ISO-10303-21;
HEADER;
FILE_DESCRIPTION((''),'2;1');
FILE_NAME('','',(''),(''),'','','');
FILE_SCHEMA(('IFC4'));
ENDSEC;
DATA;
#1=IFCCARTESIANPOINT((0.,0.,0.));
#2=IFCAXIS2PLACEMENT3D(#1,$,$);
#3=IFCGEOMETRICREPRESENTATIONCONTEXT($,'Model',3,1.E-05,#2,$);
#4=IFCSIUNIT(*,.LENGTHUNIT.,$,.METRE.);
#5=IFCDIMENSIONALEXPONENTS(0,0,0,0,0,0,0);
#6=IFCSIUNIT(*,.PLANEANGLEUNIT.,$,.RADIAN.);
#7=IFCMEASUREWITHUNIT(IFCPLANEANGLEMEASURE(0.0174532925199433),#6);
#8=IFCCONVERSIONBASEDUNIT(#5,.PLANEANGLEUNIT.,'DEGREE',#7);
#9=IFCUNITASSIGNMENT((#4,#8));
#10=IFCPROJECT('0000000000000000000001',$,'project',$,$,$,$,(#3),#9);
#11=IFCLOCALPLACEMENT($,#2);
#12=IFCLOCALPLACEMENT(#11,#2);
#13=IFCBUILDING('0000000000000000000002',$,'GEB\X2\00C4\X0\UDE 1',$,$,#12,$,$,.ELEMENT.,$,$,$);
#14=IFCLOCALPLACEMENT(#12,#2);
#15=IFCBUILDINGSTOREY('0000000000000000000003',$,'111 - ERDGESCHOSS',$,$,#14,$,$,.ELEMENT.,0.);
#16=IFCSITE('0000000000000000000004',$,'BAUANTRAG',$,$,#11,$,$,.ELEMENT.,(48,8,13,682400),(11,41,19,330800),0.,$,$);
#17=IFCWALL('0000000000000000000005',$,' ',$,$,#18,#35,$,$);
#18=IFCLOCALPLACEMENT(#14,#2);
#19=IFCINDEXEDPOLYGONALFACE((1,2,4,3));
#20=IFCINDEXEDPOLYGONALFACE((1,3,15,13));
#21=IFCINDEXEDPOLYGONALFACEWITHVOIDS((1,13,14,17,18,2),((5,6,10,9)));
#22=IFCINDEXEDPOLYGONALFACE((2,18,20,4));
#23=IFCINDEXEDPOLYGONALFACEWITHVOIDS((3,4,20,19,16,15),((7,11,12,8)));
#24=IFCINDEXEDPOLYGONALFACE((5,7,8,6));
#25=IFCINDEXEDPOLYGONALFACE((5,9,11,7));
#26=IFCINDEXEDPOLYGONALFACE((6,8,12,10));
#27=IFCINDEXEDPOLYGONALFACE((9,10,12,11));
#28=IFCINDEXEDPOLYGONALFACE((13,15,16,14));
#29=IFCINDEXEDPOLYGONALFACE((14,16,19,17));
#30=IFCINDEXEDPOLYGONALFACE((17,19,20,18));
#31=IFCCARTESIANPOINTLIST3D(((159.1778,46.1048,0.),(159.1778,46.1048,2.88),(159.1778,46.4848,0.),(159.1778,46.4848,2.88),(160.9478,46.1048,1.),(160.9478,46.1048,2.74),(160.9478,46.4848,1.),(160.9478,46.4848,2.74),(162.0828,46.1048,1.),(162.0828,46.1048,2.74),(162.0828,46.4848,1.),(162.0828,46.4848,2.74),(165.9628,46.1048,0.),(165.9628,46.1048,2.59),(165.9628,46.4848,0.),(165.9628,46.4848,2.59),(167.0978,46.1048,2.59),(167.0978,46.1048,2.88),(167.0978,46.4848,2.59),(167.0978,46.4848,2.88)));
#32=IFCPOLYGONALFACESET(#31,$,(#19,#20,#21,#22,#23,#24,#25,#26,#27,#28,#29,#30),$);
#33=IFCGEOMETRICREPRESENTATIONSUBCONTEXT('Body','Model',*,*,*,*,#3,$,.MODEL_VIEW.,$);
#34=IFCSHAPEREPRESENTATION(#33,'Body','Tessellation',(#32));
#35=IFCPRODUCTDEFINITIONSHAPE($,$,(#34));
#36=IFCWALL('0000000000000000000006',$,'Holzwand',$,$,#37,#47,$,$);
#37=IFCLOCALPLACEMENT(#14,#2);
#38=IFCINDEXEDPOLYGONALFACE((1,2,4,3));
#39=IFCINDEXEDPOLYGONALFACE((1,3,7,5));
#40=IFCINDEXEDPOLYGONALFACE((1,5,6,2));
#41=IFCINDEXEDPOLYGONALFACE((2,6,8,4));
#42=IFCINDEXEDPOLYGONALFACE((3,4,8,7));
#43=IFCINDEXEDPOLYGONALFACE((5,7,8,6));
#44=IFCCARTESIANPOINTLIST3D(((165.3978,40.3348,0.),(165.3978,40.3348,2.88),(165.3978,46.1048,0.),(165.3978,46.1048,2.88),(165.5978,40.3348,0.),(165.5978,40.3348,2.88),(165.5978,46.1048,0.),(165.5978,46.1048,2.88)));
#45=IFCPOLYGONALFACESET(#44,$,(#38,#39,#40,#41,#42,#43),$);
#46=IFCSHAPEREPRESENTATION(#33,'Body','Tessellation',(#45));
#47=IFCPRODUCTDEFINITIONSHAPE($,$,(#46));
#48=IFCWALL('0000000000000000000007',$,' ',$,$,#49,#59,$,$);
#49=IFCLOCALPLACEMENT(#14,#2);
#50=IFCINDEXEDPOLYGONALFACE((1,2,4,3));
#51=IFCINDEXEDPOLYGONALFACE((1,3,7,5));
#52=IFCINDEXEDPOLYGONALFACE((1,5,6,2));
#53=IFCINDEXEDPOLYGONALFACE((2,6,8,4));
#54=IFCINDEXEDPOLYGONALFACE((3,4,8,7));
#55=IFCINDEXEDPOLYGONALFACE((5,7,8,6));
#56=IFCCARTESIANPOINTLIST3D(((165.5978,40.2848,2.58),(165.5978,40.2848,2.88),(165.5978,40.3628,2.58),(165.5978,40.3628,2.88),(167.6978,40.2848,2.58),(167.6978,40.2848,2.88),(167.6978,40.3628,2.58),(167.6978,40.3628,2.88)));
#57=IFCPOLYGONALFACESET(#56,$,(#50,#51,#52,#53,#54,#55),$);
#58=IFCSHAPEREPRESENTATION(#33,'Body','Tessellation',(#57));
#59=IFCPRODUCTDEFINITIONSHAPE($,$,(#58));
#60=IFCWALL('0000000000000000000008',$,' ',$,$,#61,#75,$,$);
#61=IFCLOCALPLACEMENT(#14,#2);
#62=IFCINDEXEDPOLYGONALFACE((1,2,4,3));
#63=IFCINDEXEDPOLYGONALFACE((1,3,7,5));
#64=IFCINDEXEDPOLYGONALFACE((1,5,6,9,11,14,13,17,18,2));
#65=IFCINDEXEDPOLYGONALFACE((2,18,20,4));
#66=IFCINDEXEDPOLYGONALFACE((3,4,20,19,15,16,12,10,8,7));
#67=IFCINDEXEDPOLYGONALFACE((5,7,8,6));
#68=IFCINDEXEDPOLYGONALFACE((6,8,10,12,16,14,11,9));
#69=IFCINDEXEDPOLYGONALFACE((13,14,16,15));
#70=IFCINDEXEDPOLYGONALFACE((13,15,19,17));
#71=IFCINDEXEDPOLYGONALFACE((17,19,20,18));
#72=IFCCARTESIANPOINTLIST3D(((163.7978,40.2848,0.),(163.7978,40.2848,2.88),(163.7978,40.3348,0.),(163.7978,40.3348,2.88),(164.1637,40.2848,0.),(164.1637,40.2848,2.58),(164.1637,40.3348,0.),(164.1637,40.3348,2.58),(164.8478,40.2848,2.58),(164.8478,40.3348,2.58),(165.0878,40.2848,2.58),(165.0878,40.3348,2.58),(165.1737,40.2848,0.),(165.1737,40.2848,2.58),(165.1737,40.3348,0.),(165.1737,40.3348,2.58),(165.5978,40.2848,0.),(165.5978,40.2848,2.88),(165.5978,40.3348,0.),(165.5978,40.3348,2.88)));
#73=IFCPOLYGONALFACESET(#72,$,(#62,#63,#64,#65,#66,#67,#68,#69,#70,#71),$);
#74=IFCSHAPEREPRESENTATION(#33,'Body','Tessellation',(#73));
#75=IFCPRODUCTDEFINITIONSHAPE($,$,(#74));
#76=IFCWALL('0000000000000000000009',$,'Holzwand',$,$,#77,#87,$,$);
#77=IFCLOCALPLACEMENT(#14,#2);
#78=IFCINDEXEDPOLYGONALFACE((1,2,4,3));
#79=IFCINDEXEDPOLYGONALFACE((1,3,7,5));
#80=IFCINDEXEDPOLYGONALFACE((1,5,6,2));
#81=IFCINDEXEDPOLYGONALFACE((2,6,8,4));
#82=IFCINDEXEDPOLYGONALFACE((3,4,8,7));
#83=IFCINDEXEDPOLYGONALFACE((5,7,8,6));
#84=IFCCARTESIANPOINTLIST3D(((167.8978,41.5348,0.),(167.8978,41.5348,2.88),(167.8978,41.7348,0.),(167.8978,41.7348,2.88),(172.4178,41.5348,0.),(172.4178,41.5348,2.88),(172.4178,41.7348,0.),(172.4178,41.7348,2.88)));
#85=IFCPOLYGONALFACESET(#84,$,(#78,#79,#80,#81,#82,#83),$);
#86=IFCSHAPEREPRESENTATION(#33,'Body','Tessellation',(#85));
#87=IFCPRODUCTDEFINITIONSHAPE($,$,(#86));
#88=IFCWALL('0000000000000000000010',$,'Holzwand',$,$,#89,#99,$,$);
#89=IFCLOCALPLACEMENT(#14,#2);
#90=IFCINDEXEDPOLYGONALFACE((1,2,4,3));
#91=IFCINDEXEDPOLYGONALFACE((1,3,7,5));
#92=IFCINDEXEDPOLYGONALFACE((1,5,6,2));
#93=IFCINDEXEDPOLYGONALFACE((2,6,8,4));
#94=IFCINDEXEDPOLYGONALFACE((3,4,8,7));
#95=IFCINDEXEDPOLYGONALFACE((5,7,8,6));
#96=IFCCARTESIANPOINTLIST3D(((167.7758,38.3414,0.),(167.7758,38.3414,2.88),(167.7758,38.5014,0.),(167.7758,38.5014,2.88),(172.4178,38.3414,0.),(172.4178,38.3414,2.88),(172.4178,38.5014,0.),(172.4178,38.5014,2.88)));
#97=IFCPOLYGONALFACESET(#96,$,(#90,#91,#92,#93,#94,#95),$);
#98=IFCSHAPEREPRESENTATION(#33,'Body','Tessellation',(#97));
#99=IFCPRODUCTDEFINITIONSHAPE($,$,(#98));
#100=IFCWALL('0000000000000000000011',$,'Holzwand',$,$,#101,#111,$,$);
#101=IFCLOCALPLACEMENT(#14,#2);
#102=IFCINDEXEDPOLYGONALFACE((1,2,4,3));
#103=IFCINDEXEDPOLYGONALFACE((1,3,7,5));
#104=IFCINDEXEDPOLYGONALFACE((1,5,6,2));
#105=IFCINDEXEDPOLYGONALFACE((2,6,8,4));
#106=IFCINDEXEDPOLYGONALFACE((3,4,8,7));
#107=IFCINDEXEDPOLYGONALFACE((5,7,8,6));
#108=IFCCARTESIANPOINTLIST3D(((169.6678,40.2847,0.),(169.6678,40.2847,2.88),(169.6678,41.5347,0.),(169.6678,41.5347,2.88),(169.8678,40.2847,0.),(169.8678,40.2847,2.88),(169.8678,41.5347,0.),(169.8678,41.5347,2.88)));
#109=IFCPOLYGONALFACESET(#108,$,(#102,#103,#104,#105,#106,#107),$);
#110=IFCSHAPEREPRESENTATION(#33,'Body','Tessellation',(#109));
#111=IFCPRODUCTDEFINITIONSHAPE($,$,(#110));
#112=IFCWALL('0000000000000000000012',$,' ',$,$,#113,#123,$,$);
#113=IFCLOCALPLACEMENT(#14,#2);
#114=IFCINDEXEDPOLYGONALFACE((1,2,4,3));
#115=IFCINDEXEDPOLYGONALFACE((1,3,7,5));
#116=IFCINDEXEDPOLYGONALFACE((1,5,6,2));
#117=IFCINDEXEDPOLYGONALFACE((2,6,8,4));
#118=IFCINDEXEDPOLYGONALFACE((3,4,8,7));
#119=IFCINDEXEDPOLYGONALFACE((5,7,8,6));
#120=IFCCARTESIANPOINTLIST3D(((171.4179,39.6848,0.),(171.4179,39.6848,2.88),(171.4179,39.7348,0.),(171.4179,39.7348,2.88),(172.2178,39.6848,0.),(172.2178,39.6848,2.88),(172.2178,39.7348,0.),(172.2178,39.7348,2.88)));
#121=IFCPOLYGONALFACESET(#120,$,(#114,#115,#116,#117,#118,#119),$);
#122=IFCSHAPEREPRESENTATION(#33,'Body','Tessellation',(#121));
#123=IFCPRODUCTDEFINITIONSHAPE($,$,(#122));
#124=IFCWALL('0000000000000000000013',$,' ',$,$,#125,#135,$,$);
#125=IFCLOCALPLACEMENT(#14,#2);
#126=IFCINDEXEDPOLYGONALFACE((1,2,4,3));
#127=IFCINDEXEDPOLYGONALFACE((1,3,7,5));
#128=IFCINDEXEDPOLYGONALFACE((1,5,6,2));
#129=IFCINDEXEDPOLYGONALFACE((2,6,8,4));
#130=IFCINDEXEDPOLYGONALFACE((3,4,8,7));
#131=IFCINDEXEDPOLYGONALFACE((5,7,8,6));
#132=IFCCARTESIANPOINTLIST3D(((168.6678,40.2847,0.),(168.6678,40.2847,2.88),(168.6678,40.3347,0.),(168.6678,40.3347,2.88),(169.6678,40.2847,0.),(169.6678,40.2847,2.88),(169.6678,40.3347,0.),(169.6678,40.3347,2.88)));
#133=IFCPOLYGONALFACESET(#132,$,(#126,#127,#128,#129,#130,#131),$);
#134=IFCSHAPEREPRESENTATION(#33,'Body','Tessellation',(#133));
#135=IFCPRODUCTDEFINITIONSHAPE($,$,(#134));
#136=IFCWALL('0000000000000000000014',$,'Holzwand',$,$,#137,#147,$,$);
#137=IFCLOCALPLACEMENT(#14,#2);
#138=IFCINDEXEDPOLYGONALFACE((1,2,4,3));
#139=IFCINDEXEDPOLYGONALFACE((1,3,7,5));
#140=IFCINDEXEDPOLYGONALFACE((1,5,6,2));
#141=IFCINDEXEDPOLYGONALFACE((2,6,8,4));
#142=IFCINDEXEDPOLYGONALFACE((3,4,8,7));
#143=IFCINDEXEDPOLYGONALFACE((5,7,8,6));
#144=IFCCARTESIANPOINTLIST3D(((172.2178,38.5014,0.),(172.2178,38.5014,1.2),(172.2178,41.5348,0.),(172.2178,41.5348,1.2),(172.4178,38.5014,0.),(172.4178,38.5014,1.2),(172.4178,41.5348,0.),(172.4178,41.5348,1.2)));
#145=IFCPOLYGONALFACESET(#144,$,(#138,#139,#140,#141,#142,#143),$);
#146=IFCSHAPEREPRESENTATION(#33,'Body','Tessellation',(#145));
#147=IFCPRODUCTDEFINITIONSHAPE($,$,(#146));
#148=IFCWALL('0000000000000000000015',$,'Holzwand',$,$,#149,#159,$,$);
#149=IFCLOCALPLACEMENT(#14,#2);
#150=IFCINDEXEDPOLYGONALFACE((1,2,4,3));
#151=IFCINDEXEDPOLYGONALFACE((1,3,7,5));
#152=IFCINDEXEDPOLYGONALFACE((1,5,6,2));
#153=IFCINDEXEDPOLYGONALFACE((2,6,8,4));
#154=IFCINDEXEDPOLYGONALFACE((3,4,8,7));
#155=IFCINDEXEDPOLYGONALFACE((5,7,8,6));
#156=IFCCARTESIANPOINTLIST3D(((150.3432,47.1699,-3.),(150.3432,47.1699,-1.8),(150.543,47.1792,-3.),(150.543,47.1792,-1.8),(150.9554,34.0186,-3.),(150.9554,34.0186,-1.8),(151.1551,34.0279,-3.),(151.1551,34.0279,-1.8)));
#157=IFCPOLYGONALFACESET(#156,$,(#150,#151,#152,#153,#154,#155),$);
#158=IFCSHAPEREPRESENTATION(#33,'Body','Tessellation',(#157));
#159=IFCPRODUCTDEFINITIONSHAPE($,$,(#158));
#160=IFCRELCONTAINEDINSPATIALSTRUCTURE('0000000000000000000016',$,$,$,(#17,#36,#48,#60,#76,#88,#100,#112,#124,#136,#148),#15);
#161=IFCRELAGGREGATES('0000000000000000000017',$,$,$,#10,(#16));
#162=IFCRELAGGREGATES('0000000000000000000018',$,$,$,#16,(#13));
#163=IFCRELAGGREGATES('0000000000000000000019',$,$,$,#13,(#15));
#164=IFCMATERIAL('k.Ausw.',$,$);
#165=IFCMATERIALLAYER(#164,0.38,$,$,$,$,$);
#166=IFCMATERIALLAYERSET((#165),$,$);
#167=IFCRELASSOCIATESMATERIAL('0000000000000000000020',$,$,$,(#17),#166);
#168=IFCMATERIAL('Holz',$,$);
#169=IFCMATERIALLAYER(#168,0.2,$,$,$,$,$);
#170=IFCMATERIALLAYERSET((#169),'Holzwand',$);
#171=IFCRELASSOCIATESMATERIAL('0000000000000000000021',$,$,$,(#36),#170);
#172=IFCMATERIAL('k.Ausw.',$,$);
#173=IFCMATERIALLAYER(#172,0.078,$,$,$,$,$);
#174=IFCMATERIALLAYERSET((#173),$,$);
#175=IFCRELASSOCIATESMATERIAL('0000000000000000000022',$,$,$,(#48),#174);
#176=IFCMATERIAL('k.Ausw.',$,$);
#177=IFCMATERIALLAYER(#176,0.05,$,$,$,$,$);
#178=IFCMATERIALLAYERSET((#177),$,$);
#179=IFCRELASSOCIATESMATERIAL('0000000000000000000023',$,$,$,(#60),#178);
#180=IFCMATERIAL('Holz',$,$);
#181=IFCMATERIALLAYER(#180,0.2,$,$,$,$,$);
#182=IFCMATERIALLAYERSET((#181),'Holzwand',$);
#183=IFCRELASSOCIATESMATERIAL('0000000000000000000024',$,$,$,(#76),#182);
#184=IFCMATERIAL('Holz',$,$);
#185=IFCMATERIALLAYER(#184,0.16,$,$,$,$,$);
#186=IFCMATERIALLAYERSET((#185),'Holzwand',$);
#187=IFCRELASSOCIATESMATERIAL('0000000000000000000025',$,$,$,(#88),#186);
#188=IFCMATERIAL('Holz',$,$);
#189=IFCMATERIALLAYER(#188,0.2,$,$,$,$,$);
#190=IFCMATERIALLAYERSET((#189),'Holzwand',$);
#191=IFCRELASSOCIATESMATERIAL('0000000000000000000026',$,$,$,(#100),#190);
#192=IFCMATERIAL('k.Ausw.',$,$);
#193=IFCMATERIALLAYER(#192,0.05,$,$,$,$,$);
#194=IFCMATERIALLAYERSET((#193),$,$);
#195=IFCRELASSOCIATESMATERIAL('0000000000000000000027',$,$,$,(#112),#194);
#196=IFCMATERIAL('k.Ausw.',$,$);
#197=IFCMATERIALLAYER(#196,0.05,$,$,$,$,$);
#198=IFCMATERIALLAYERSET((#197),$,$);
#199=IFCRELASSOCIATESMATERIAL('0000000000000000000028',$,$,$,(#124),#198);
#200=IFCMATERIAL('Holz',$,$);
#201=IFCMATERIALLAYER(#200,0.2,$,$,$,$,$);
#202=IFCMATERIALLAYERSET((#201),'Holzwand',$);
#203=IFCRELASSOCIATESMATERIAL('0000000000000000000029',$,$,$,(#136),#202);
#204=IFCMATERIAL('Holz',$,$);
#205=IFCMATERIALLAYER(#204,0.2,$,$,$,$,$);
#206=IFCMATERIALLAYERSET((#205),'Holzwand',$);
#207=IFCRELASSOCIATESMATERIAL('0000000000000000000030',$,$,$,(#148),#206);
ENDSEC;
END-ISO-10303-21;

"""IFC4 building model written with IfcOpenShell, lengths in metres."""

from ifc_helpers import new_model, entity, si_unit, converted_unit, frame, frame_2d, origin, origin_with_axes, place, context, subcontext, project, spatial, polyline, rectangle, outline, extrude, material, layer, layer_set, layer_usage, element, save


model = new_model("IFC4")

# Units and contexts
model_context = context("Model", 3, precision=1e-05, world=origin())
body_context = subcontext(model_context, "Body", "Model", "MODEL_VIEW")
ifc_project = project(units=[si_unit("LENGTHUNIT", "METRE"), converted_unit("PLANEANGLEUNIT", "DEGREE", entity("IfcPlaneAngleMeasure", 0.0174532925199433), si_unit("PLANEANGLEUNIT", "RADIAN"), dimensions=[0, 0, 0, 0, 0, 0, 0])], contexts=[model_context])

# Site, building, storey
site_placement = place(None, origin())
site = spatial("IfcSite", under=ifc_project, at=site_placement, Name="BAUANTRAG", CompositionType="ELEMENT", RefLatitude=(48, 8, 13, 682400), RefLongitude=(11, 41, 19, 330800), RefElevation=0.0)
building_placement = place(site_placement, origin())
building = spatial("IfcBuilding", under=site, at=building_placement, Name="GEBÄUDE 1", CompositionType="ELEMENT")
storey_placement = place(building_placement, origin())
storey = spatial("IfcBuildingStorey", under=building, at=storey_placement, Name="111 - ERDGESCHOSS", CompositionType="ELEMENT", Elevation=0.0)

# Wall, openings
ifc_material_1 = material(Name="k.Ausw.")
ifc_layer_1 = layer(ifc_material_1, 0.38)
ifc_layer_set_1 = layer_set([ifc_layer_1])
ifc_layer_usage_1 = layer_usage(ifc_layer_set_1, "AXIS2", "POSITIVE", 0.0)
wall_1_placement = place(storey_placement, frame((167.0978, 46.4848, 0.0), z_axis=(0.0, 0.0, 1.0), x_axis=(-1.0, 0.0, 0.0)))
wall_1 = element("IfcWall", 1, at=wall_1_placement, inside=storey, material=ifc_layer_usage_1, Name=" ", context=body_context, shape_type="SweptSolid", body=[
    extrude(rectangle(XDim=7.92, YDim=0.38, at=frame_2d((3.96, 0.19), x_axis=(1.0, 0.0))), origin_with_axes(), (0.0, 0.0, 1.0), 2.88),
])
opening_1_placement = place(wall_1_placement, frame((6.15, 0.38, 1.0), z_axis=(0.0, -1.0, 0.0), x_axis=(0.0, 0.0, 1.0)))
element("IfcOpeningElement", 2, at=opening_1_placement, cuts=wall_1, ObjectType="Opening", context=body_context, shape_type="SweptSolid", body=[
    extrude(outline(polyline([(0.0, 1.135), (1.74, 1.135), (1.74, 0.0), (0.0, 0.0), (0.0, 1.135)])), origin_with_axes(), (0.0, 0.0, 1.0), 0.38),
])
opening_2_placement = place(wall_1_placement, frame((0.0, 0.0, -0.15), z_axis=(0.0, 1.0, 0.0), x_axis=(0.0, 0.0, 1.0)))
element("IfcOpeningElement", 3, at=opening_2_placement, cuts=wall_1, ObjectType="Opening", context=body_context, shape_type="SweptSolid", body=[
    extrude(outline(polyline([(0.0, 1.135), (2.74, 1.135), (2.74, 0.0), (0.0, 0.0), (0.0, 1.135)])), origin_with_axes(), (0.0, 0.0, 1.0), 0.38),
])

# Wall
ifc_material_2 = material(Name="Holz")
ifc_layer_2 = layer(ifc_material_2, 0.2)
ifc_layer_set_2 = layer_set([ifc_layer_2], Name="Holzwand")
ifc_layer_usage_2 = layer_usage(ifc_layer_set_2, "AXIS2", "POSITIVE", 0.0)
wall_2_placement = place(storey_placement, frame((165.3978, 46.1048, 0.0), z_axis=(0.0, 0.0, 1.0), x_axis=(0.0, -1.0, 0.0)))
element("IfcWall", 4, at=wall_2_placement, inside=storey, material=ifc_layer_usage_2, Name="Holzwand", context=body_context, shape_type="SweptSolid", body=[
    extrude(rectangle(XDim=5.77, YDim=0.2, at=frame_2d((2.885, 0.1), x_axis=(1.0, 0.0))), origin_with_axes(), (0.0, 0.0, 1.0), 2.88),
])

# Wall, opening
ifc_material_3 = material(Name="k.Ausw.")
ifc_layer_3 = layer(ifc_material_3, 0.078)
ifc_layer_set_3 = layer_set([ifc_layer_3])
ifc_layer_usage_3 = layer_usage(ifc_layer_set_3, "AXIS2", "POSITIVE", 0.0)
wall_3_placement = place(storey_placement, frame((165.5978, 40.2848, 0.0)))
wall_3 = element("IfcWall", 5, at=wall_3_placement, inside=storey, material=ifc_layer_usage_3, Name=" ", context=body_context, shape_type="SweptSolid", body=[
    extrude(rectangle(XDim=2.1, YDim=0.078, at=frame_2d((1.05, 0.039), x_axis=(1.0, 0.0))), origin_with_axes(), (0.0, 0.0, 1.0), 2.88),
])
opening_3_placement = place(wall_3_placement, frame((0.0, 0.0, -0.14), z_axis=(0.0, 1.0, 0.0), x_axis=(0.0, 0.0, 1.0)))
element("IfcOpeningElement", 6, at=opening_3_placement, cuts=wall_3, ObjectType="Opening", context=body_context, shape_type="SweptSolid", body=[
    extrude(outline(polyline([(0.0, 2.1), (2.72, 2.1), (2.72, 0.0), (0.0, 0.0), (0.0, 2.1)])), origin_with_axes(), (0.0, 0.0, 1.0), 0.078),
])

# Wall, openings
ifc_material_4 = material(Name="k.Ausw.")
ifc_layer_4 = layer(ifc_material_4, 0.05)
ifc_layer_set_4 = layer_set([ifc_layer_4])
ifc_layer_usage_4 = layer_usage(ifc_layer_set_4, "AXIS2", "POSITIVE", 0.0)
wall_4_placement = place(storey_placement, frame((165.5978, 40.3348, 0.0), z_axis=(0.0, 0.0, 1.0), x_axis=(-1.0, 0.0, 0.0)))
wall_4 = element("IfcWall", 7, at=wall_4_placement, inside=storey, material=ifc_layer_usage_4, Name=" ", context=body_context, shape_type="SweptSolid", body=[
    extrude(rectangle(XDim=1.8, YDim=0.05, at=frame_2d((0.9, 0.025), x_axis=(1.0, 0.0))), origin_with_axes(), (0.0, 0.0, 1.0), 2.88),
])
opening_4_placement = place(wall_4_placement, frame((1.4341, 0.05, -0.14), z_axis=(0.0, -1.0, 0.0), x_axis=(0.0, 0.0, 1.0)))
element("IfcOpeningElement", 8, at=opening_4_placement, cuts=wall_4, ObjectType="Opening", context=body_context, shape_type="SweptSolid", body=[
    extrude(outline(polyline([(0.0, 1.01), (2.72, 1.01), (2.72, 0.0), (0.0, 0.0), (0.0, 1.01)])), origin_with_axes(), (0.0, 0.0, 1.0), 0.05),
])
opening_5_placement = place(wall_4_placement, frame((0.51, 0.0, -0.14), z_axis=(0.0, 1.0, 0.0), x_axis=(0.0, 0.0, 1.0)))
element("IfcOpeningElement", 9, at=opening_5_placement, cuts=wall_4, ObjectType="Opening", context=body_context, shape_type="SweptSolid", body=[
    extrude(outline(polyline([(0.0, 0.24), (2.72, 0.24), (2.72, 0.0), (0.0, 0.0), (0.0, 0.24)])), origin_with_axes(), (0.0, 0.0, 1.0), 0.05),
])

# Walls
ifc_material_5 = material(Name="Holz")
ifc_layer_5 = layer(ifc_material_5, 0.2)
ifc_layer_set_5 = layer_set([ifc_layer_5], Name="Holzwand")
ifc_layer_usage_5 = layer_usage(ifc_layer_set_5, "AXIS2", "POSITIVE", 0.0)
wall_5_placement = place(storey_placement, frame((172.4178, 41.7348, 0.0), z_axis=(0.0, 0.0, 1.0), x_axis=(-1.0, 0.0, 0.0)))
element("IfcWall", 10, at=wall_5_placement, inside=storey, material=ifc_layer_usage_5, Name="Holzwand", context=body_context, shape_type="SweptSolid", body=[
    extrude(rectangle(XDim=4.52, YDim=0.2, at=frame_2d((2.26, 0.1), x_axis=(1.0, 0.0))), origin_with_axes(), (0.0, 0.0, 1.0), 2.88),
])
ifc_material_6 = material(Name="Holz")
ifc_layer_6 = layer(ifc_material_6, 0.16)
ifc_layer_set_6 = layer_set([ifc_layer_6], Name="Holzwand")
ifc_layer_usage_6 = layer_usage(ifc_layer_set_6, "AXIS2", "POSITIVE", 0.0)
wall_6_placement = place(storey_placement, frame((172.4178, 38.5014, 0.0), z_axis=(0.0, 0.0, 1.0), x_axis=(-1.0, 0.0, 0.0)))
element("IfcWall", 11, at=wall_6_placement, inside=storey, material=ifc_layer_usage_6, Name="Holzwand", context=body_context, shape_type="SweptSolid", body=[
    extrude(rectangle(XDim=4.642, YDim=0.16, at=frame_2d((2.321, 0.08), x_axis=(1.0, 0.0))), origin_with_axes(), (0.0, 0.0, 1.0), 2.88),
])
ifc_material_7 = material(Name="Holz")
ifc_layer_7 = layer(ifc_material_7, 0.2)
ifc_layer_set_7 = layer_set([ifc_layer_7], Name="Holzwand")
ifc_layer_usage_7 = layer_usage(ifc_layer_set_7, "AXIS2", "POSITIVE", 0.0)
wall_7_placement = place(storey_placement, frame((169.8678, 40.2847, 0.0), z_axis=(0.0, 0.0, 1.0), x_axis=(0.0, 1.0, 0.0)))
element("IfcWall", 12, at=wall_7_placement, inside=storey, material=ifc_layer_usage_7, Name="Holzwand", context=body_context, shape_type="SweptSolid", body=[
    extrude(rectangle(XDim=1.25, YDim=0.2, at=frame_2d((0.625, 0.1), x_axis=(1.0, 0.0))), origin_with_axes(), (0.0, 0.0, 1.0), 2.88),
])
ifc_material_8 = material(Name="k.Ausw.")
ifc_layer_8 = layer(ifc_material_8, 0.05)
ifc_layer_set_8 = layer_set([ifc_layer_8])
ifc_layer_usage_8 = layer_usage(ifc_layer_set_8, "AXIS2", "POSITIVE", 0.0)
wall_8_placement = place(storey_placement, frame((172.2178, 39.7348, 0.0), z_axis=(0.0, 0.0, 1.0), x_axis=(-1.0, 0.0, 0.0)))
element("IfcWall", 13, at=wall_8_placement, inside=storey, material=ifc_layer_usage_8, Name=" ", context=body_context, shape_type="SweptSolid", body=[
    extrude(rectangle(XDim=0.7998, YDim=0.05, at=frame_2d((0.3999, 0.025), x_axis=(1.0, 0.0))), origin_with_axes(), (0.0, 0.0, 1.0), 2.88),
])
ifc_material_9 = material(Name="k.Ausw.")
ifc_layer_9 = layer(ifc_material_9, 0.05)
ifc_layer_set_9 = layer_set([ifc_layer_9])
ifc_layer_usage_9 = layer_usage(ifc_layer_set_9, "AXIS2", "POSITIVE", 0.0)
wall_9_placement = place(storey_placement, frame((168.6678, 40.2847, 0.0)))
element("IfcWall", 14, at=wall_9_placement, inside=storey, material=ifc_layer_usage_9, Name=" ", context=body_context, shape_type="SweptSolid", body=[
    extrude(rectangle(XDim=1.0, YDim=0.05, at=frame_2d((0.5, 0.025), x_axis=(1.0, 0.0))), origin_with_axes(), (0.0, 0.0, 1.0), 2.88),
])
ifc_material_10 = material(Name="Holz")
ifc_layer_10 = layer(ifc_material_10, 0.2)
ifc_layer_set_10 = layer_set([ifc_layer_10], Name="Holzwand")
ifc_layer_usage_10 = layer_usage(ifc_layer_set_10, "AXIS2", "POSITIVE", 0.0)
wall_10_placement = place(storey_placement, frame((172.4178, 38.5014, 0.0), z_axis=(0.0, 0.0, 1.0), x_axis=(0.0, 1.0, 0.0)))
element("IfcWall", 15, at=wall_10_placement, inside=storey, material=ifc_layer_usage_10, Name="Holzwand", context=body_context, shape_type="SweptSolid", body=[
    extrude(rectangle(XDim=3.0334, YDim=0.2, at=frame_2d((1.5167, 0.1), x_axis=(1.0, 0.0))), origin_with_axes(), (0.0, 0.0, 1.0), 1.2),
])
ifc_material_11 = material(Name="Holz")
ifc_layer_11 = layer(ifc_material_11, 0.2)
ifc_layer_set_11 = layer_set([ifc_layer_11], Name="Holzwand")
ifc_layer_usage_11 = layer_usage(ifc_layer_set_11, "AXIS2", "POSITIVE", 0.0)
wall_11_placement = place(storey_placement, frame((150.3432, 47.1699, -3.0), z_axis=(0.0, 0.0, 1.0), x_axis=(0.046495, -0.998919, 0.0)))
element("IfcWall", 16, at=wall_11_placement, inside=storey, material=ifc_layer_usage_11, Name="Holzwand", context=body_context, shape_type="SweptSolid", body=[
    extrude(rectangle(XDim=13.1655, YDim=0.2, at=frame_2d((6.5828, 0.1), x_axis=(1.0, 0.0))), origin_with_axes(), (0.0, 0.0, 1.0), 1.2),
])

save(model, "model.ifc")
